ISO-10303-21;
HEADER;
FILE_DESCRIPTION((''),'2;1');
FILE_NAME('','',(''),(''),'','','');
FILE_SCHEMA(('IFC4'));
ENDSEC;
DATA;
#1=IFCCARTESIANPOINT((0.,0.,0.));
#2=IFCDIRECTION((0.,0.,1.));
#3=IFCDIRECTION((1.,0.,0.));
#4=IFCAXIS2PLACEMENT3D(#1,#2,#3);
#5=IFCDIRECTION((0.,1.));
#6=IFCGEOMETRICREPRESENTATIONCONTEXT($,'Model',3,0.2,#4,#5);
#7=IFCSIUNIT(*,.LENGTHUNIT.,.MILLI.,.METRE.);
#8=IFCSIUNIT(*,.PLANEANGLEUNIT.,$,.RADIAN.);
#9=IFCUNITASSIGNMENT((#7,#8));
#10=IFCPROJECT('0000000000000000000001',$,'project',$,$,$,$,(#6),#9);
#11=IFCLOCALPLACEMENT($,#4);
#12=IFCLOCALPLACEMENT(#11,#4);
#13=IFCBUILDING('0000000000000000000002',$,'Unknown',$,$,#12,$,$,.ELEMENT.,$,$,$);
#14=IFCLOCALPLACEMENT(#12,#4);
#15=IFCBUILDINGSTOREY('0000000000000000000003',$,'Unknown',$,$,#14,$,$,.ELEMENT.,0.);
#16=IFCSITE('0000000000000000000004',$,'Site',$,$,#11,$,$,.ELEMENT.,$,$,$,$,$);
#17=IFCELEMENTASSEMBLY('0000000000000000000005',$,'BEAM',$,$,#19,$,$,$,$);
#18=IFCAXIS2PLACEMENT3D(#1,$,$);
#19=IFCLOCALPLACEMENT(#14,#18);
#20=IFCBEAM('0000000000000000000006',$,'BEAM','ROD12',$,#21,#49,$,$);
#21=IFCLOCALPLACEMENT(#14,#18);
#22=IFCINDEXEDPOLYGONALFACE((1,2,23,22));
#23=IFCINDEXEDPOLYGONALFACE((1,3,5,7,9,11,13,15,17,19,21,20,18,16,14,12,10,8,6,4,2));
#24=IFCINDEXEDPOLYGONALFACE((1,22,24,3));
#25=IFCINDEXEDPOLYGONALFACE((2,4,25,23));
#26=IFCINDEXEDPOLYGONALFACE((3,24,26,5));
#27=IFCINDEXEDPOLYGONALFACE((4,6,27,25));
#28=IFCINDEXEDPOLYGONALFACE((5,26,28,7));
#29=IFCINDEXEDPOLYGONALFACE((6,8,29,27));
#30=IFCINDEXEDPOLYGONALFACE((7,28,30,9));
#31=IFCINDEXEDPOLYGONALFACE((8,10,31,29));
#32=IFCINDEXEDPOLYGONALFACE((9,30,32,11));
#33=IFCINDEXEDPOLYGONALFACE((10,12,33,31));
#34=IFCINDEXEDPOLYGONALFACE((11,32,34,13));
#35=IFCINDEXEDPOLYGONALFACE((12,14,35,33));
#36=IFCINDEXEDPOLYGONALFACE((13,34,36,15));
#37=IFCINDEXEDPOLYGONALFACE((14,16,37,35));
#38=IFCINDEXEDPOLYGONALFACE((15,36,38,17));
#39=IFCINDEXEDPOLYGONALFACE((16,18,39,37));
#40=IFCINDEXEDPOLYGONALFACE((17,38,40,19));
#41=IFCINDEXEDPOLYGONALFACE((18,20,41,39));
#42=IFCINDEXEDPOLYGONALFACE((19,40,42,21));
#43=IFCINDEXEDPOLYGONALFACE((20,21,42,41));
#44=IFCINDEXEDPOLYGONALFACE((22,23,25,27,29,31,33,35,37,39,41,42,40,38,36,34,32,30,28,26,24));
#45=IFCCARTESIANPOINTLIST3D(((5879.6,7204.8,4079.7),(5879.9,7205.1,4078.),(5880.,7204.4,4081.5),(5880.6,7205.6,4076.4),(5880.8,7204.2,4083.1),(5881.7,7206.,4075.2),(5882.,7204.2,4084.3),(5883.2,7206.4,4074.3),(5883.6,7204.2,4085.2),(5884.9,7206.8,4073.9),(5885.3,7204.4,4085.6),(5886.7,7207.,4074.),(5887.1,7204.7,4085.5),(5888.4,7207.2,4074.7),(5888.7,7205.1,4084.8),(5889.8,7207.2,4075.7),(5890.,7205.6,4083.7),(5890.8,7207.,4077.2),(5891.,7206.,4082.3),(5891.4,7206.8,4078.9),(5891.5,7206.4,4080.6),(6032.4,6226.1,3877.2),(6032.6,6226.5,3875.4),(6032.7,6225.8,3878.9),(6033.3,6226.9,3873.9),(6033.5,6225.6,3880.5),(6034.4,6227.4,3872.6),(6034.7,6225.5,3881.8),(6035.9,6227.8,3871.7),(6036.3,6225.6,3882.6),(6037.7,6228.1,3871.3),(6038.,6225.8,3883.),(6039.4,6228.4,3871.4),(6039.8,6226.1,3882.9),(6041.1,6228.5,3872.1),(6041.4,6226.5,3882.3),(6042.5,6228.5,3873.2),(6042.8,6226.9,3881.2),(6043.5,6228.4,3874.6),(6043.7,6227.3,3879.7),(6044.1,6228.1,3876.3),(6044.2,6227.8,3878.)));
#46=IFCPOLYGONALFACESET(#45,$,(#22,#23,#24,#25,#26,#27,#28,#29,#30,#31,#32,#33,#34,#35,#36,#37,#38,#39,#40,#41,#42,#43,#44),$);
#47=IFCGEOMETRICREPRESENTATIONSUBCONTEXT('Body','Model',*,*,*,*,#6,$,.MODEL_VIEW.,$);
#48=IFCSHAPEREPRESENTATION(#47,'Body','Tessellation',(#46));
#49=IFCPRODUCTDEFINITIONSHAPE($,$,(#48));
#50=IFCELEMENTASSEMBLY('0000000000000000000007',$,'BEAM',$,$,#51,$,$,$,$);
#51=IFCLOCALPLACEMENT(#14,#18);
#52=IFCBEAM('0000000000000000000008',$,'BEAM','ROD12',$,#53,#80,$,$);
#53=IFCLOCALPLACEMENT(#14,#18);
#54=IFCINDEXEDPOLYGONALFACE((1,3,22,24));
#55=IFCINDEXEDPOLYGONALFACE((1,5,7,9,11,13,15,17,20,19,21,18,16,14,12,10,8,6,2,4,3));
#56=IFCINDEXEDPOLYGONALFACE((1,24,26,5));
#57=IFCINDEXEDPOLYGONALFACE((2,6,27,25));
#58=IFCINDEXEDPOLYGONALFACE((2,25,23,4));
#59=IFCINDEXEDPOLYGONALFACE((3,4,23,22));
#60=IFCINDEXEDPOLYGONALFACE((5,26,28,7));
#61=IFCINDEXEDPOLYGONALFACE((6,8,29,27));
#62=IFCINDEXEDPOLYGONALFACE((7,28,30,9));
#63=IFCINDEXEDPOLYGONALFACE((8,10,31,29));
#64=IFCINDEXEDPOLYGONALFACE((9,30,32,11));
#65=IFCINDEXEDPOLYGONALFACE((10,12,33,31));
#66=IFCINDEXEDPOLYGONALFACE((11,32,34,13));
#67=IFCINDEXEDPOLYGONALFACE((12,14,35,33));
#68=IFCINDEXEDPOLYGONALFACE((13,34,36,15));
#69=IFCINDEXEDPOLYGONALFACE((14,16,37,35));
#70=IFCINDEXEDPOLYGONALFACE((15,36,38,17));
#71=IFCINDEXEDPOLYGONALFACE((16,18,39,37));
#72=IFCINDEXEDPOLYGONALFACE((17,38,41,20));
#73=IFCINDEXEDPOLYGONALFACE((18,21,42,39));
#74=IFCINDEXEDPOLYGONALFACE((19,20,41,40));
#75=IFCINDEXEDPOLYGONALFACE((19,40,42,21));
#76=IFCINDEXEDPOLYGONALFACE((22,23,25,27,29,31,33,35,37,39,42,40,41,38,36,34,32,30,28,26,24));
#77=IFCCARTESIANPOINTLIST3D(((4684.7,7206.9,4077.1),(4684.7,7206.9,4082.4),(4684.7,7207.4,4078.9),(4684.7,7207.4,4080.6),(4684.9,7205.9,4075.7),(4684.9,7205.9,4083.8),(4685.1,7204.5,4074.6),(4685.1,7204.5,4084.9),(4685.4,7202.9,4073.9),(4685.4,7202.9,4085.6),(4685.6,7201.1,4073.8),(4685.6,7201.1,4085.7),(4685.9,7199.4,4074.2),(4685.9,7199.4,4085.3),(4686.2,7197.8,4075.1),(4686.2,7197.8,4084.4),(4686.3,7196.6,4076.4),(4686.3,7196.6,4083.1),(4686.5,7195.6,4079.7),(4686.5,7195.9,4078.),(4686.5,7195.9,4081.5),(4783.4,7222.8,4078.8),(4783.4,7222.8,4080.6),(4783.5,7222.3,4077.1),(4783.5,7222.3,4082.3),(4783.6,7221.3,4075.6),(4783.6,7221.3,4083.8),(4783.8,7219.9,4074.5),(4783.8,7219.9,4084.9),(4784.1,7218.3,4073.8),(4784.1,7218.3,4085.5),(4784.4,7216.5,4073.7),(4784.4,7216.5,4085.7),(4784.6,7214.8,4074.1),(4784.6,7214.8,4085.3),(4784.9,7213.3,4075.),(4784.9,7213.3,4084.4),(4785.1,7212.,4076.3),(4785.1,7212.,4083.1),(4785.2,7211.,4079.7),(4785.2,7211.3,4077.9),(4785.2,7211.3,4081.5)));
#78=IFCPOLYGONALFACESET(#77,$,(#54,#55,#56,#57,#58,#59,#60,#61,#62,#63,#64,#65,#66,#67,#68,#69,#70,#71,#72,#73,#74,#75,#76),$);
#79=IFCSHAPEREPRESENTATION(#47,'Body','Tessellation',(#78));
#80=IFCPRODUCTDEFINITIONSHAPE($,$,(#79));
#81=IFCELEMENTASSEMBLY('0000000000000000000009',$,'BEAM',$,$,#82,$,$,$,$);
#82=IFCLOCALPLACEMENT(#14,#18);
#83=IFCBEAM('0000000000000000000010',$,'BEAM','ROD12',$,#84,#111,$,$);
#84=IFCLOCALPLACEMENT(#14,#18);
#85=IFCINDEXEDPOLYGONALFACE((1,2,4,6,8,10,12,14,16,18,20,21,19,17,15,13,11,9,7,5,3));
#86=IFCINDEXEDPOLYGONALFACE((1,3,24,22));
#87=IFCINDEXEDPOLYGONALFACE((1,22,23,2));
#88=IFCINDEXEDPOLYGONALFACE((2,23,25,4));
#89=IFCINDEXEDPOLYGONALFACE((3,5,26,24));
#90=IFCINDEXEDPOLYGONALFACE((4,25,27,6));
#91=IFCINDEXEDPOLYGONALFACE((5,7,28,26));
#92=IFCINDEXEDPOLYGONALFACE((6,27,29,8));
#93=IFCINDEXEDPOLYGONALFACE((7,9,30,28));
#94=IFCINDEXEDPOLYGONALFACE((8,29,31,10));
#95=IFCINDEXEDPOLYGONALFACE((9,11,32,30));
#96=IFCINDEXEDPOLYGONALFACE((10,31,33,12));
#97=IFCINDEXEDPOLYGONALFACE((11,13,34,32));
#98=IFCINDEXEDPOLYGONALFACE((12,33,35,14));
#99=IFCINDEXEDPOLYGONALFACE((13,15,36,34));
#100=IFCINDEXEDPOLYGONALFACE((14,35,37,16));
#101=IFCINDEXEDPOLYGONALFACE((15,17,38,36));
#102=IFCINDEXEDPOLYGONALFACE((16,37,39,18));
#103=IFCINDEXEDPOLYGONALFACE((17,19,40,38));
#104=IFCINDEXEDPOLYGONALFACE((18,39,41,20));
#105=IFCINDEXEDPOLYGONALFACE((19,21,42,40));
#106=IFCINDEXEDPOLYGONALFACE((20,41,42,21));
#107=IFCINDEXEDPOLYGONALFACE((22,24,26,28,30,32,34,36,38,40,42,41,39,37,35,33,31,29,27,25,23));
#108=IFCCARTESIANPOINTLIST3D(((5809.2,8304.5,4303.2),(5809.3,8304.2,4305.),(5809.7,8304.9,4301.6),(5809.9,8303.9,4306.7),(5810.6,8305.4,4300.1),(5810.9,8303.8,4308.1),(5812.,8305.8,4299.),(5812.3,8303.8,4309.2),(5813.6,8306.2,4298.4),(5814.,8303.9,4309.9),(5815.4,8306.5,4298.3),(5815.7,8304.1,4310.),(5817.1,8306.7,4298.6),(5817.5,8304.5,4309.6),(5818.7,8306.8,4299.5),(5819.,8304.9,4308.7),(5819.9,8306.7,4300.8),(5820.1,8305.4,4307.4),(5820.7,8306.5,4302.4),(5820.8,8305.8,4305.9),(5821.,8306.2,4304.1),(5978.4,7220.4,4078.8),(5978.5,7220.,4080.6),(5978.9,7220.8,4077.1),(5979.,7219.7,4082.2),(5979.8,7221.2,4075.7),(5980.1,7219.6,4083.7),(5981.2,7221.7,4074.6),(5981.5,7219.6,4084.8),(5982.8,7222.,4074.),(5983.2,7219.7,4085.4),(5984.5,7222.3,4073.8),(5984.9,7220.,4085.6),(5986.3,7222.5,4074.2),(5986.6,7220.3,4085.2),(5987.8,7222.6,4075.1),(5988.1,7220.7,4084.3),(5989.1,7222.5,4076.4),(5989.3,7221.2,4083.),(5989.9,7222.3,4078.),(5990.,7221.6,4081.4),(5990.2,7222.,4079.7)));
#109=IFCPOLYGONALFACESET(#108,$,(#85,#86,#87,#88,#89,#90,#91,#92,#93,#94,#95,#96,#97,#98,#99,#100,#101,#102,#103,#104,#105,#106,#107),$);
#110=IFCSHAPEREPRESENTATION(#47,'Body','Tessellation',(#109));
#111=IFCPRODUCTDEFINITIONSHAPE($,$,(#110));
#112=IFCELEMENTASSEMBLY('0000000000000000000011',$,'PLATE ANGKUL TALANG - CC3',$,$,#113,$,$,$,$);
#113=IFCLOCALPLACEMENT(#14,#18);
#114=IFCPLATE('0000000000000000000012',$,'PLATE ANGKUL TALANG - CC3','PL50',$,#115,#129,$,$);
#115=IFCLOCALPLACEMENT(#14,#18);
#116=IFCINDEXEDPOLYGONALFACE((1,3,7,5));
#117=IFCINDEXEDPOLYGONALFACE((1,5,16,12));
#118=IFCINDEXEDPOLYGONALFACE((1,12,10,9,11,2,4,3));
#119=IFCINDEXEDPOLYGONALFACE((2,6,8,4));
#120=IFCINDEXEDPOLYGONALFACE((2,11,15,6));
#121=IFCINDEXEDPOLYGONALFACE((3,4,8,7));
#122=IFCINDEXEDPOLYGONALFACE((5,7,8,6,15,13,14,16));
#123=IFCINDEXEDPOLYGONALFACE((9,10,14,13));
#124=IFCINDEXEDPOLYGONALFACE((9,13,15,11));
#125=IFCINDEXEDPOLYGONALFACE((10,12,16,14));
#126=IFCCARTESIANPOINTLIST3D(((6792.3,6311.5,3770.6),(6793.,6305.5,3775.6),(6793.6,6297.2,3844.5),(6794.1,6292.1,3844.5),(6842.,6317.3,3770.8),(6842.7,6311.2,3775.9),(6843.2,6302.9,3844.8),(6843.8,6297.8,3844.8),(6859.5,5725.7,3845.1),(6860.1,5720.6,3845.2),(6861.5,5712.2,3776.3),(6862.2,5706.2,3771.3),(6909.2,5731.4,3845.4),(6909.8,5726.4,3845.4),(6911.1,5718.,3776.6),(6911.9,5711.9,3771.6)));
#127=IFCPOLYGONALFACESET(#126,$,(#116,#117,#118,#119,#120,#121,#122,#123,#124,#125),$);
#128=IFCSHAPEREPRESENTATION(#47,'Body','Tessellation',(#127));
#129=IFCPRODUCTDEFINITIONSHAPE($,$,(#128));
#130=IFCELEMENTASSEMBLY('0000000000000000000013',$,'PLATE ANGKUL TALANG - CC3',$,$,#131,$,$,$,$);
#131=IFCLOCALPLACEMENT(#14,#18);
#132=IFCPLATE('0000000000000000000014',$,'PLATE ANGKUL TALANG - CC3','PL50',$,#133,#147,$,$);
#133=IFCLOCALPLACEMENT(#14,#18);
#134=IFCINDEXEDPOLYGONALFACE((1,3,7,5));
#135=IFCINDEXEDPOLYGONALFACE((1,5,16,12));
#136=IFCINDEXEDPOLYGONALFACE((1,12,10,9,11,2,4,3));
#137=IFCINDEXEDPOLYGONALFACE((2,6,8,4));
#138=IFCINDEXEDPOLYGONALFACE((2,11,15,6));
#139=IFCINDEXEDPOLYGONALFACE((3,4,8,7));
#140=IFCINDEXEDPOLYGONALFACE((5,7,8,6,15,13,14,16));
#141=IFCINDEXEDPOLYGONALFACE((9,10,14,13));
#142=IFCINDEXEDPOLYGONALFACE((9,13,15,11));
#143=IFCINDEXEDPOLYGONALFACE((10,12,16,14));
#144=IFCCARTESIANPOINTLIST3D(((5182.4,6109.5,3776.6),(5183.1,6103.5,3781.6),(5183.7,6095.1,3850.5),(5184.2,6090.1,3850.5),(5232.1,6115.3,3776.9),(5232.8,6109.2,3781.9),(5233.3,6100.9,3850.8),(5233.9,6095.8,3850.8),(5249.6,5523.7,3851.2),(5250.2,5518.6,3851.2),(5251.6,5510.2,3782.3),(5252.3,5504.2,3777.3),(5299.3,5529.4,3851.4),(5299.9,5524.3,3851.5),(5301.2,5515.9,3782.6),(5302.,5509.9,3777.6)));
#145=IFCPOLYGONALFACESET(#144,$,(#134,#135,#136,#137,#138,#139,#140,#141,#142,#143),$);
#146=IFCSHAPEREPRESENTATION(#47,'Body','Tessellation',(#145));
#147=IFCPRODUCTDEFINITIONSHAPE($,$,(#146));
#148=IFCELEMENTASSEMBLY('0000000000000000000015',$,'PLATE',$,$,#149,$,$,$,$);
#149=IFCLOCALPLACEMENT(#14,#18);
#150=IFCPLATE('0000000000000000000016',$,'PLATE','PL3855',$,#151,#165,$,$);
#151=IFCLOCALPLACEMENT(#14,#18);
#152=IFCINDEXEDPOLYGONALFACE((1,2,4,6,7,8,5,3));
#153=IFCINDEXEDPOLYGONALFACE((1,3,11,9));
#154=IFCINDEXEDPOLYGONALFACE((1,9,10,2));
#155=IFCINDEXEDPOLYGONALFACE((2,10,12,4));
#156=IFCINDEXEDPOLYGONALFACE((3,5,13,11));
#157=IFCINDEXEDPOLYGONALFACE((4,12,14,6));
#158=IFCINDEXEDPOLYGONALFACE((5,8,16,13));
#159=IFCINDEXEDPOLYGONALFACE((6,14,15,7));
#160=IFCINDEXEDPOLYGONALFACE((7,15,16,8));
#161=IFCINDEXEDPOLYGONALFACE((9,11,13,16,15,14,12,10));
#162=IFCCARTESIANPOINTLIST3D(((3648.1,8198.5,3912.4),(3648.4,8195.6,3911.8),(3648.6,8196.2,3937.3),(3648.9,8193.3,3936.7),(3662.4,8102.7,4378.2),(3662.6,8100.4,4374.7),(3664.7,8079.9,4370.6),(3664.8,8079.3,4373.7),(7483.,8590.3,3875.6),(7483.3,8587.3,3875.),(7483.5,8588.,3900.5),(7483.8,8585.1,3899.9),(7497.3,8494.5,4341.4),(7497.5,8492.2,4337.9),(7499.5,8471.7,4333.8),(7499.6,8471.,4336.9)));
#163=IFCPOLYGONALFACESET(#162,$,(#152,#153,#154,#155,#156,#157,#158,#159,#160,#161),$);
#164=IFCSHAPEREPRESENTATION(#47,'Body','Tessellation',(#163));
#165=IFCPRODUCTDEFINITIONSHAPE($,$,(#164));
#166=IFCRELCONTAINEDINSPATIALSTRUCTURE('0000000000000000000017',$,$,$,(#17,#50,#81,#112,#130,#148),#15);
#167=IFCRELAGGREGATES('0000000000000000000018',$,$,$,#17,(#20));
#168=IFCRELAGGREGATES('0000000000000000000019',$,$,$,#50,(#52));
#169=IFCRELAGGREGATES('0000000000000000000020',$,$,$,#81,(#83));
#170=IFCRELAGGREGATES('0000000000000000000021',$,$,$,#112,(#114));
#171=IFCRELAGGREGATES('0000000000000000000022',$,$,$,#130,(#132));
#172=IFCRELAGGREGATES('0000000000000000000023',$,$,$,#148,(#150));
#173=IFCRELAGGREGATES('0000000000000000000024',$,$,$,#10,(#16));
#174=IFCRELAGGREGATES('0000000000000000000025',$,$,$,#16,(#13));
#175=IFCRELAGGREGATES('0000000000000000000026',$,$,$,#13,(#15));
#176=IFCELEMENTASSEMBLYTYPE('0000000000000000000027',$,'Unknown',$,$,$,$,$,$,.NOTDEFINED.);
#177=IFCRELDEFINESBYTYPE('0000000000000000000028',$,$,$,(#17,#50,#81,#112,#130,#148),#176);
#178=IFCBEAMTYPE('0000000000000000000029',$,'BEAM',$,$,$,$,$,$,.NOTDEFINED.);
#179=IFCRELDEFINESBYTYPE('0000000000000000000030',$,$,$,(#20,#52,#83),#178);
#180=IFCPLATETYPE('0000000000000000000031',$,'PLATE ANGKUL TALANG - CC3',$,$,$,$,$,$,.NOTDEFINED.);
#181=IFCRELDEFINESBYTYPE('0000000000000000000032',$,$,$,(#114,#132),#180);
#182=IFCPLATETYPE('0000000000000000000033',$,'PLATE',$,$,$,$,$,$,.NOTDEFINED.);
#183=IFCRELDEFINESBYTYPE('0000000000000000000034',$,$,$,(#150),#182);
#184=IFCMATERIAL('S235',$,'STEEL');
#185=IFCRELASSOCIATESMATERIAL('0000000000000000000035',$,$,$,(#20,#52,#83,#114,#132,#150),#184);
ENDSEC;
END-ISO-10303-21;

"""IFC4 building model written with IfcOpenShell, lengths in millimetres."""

from ifc_helpers import new_model, si_unit, direction, frame, origin_with_axes, origin_2d_with_axis, place, context, subcontext, project, spatial, line, indexed_curve, circle, outline, extrude, material, material_profile, profile_set, profile_usage, type_object, element, aggregate, save


model = new_model("IFC4")

# Units and contexts
model_context = context("Model", 3, precision=0.2, world=origin_with_axes(), true_north=direction((0.0, 1.0)))
body_context = subcontext(model_context, "Body", "Model", "MODEL_VIEW")
ifc_project = project(units=[si_unit("LENGTHUNIT", "METRE", prefix="MILLI"), si_unit("PLANEANGLEUNIT", "RADIAN")], contexts=[model_context])

# Site, building, storey
site_placement = place(None, origin_with_axes())
site = spatial("IfcSite", under=ifc_project, at=site_placement, Name="Site", CompositionType="ELEMENT")
building_placement = place(site_placement, origin_with_axes())
building = spatial("IfcBuilding", under=site, at=building_placement, Name="Unknown", CompositionType="ELEMENT")
storey_placement = place(building_placement, origin_with_axes())
storey = spatial("IfcBuildingStorey", under=building, at=storey_placement, Name="Unknown", CompositionType="ELEMENT", Elevation=0.0)

# Element assemblies, beams
element_assembly_type = type_object("IfcElementAssemblyType", Name="Unknown", PredefinedType="NOTDEFINED")
ifc_material_1 = material(Name="S235", Category="STEEL")
ifc_material_profile_1 = material_profile(ifc_material_1, circle(Radius=6.0, at=origin_2d_with_axis()), Name="ROD12")
ifc_profile_set_1 = profile_set([ifc_material_profile_1])
ifc_profile_usage_1 = profile_usage(ifc_profile_set_1, cardinal=5)
beam_type_1 = type_object("IfcBeamType", Name="BEAM", PredefinedType="NOTDEFINED")
assembly_1_placement = place(storey_placement, frame((5885.6, 7205.7, 4079.7), z_axis=(-0.988043, -0.154176, 0.0), x_axis=(0.151049, -0.968005, -0.200378)))
assembly_1 = element("IfcElementAssembly", 1, at=assembly_1_placement, inside=storey, type_object=element_assembly_type, Name="BEAM")
beam_1_placement = place(assembly_1_placement, origin_with_axes())
beam_1 = element("IfcBeam", 2, at=beam_1_placement, type_object=beam_type_1, material=ifc_profile_usage_1, Name="BEAM", Description="ROD12", context=body_context, shape_type="SolidModel", body=[
    extrude(circle(Radius=6.0, at=origin_2d_with_axis()), frame((0.0, 0.0, 0.0), z_axis=(-1.0, 0.0, 0.0), x_axis=(0.0, 0.0, 1.0)), (0.0, 0.0, -1.0), 1011.0),
])
aggregate(assembly_1, [beam_1])
assembly_2_placement = place(storey_placement, frame((4685.6, 7201.5, 4079.7), z_axis=(0.154276, -0.988028, 0.0), x_axis=(0.988028, 0.154276, -0.000497)))
assembly_2 = element("IfcElementAssembly", 3, at=assembly_2_placement, inside=storey, type_object=element_assembly_type, Name="BEAM")
beam_2_placement = place(assembly_2_placement, origin_with_axes())
beam_2 = element("IfcBeam", 4, at=beam_2_placement, type_object=beam_type_1, material=ifc_profile_usage_1, Name="BEAM", Description="ROD12", context=body_context, shape_type="SolidModel", body=[
    extrude(circle(Radius=6.0, at=origin_2d_with_axis()), frame((0.0, 0.0, 0.0), z_axis=(-1.0, 0.0, 0.0), x_axis=(0.0, 0.0, 1.0)), (0.0, 0.0, -1.0), 99.9),
])
aggregate(assembly_2, [beam_2])
assembly_3_placement = place(storey_placement, frame((5984.3, 7221.1, 4079.7), z_axis=(0.988043, 0.154176, 0.0), x_axis=(-0.151049, 0.968005, 0.200378)))
assembly_3 = element("IfcElementAssembly", 5, at=assembly_3_placement, inside=storey, type_object=element_assembly_type, Name="BEAM")
beam_3_placement = place(assembly_3_placement, origin_with_axes())
beam_3 = element("IfcBeam", 6, at=beam_3_placement, type_object=beam_type_1, material=ifc_profile_usage_1, Name="BEAM", Description="ROD12", context=body_context, shape_type="SolidModel", body=[
    extrude(circle(Radius=6.0, at=origin_2d_with_axis()), frame((0.0, 0.0, 0.0), z_axis=(-1.0, 0.0, 0.0), x_axis=(0.0, 0.0, 1.0)), (0.0, 0.0, -1.0), 1120.0),
])
aggregate(assembly_3, [beam_3])

# Element assemblies, plates
assembly_4_placement = place(storey_placement, frame((6818.4, 6300.0, 3844.6), z_axis=(-0.99339, -0.114647, -0.005686), x_axis=(-0.01641, 0.190863, -0.98148)))
assembly_4 = element("IfcElementAssembly", 7, at=assembly_4_placement, inside=storey, type_object=element_assembly_type, Name="PLATE ANGKUL TALANG - CC3")
ifc_material_profile_2 = material_profile(ifc_material_1, outline(indexed_curve([(0.0, 0.0), (75.4, 0.0), (-42.1, 598.0), (-111.8, 569.5), (-110.8, 564.5), (-45.8, 591.0), (69.3, 5.0), (-1.0, 5.0)], segments=[line(1, 2, 3, 4, 5, 6, 7, 8, 1)])), Name="PL50")
ifc_profile_set_2 = profile_set([ifc_material_profile_2])
ifc_profile_usage_2 = profile_usage(ifc_profile_set_2, cardinal=5)
plate_type_1 = type_object("IfcPlateType", Name="PLATE ANGKUL TALANG - CC3", PredefinedType="NOTDEFINED")
plate_1_placement = place(assembly_4_placement, origin_with_axes())
plate_1 = element("IfcPlate", 8, at=plate_1_placement, type_object=plate_type_1, material=ifc_profile_usage_2, Name="PLATE ANGKUL TALANG - CC3", Description="PL50", context=body_context, shape_type="SolidModel", body=[
    extrude(outline(indexed_curve([(0.0, 0.0), (75.4, 0.0), (-42.1, 598.0), (-111.8, 569.5), (-110.8, 564.5), (-45.8, 591.0), (69.3, 5.0), (-1.0, 5.0)], segments=[line(1, 2, 3, 4, 5, 6, 7, 8, 1)])), frame((0.0, 0.0, 25.0), z_axis=(0.0, 0.0, 1.0), x_axis=(1.0, 0.0, 0.0)), (0.0, 0.0, -1.0), 50.0),
])
aggregate(assembly_4, [plate_1])
assembly_5_placement = place(storey_placement, frame((5208.5, 6098.0, 3850.7), z_axis=(-0.99339, -0.114647, -0.005686), x_axis=(-0.01641, 0.190863, -0.98148)))
assembly_5 = element("IfcElementAssembly", 9, at=assembly_5_placement, inside=storey, type_object=element_assembly_type, Name="PLATE ANGKUL TALANG - CC3")
plate_2_placement = place(assembly_5_placement, origin_with_axes())
plate_2 = element("IfcPlate", 10, at=plate_2_placement, type_object=plate_type_1, material=ifc_profile_usage_2, Name="PLATE ANGKUL TALANG - CC3", Description="PL50", context=body_context, shape_type="SolidModel", body=[
    extrude(outline(indexed_curve([(0.0, 0.0), (75.4, 0.0), (-42.1, 598.0), (-111.8, 569.5), (-110.8, 564.5), (-45.8, 591.0), (69.3, 5.0), (-1.0, 5.0)], segments=[line(1, 2, 3, 4, 5, 6, 7, 8, 1)])), frame((0.0, 0.0, 25.0), z_axis=(0.0, 0.0, 1.0), x_axis=(1.0, 0.0, 0.0)), (0.0, 0.0, -1.0), 50.0),
])
aggregate(assembly_5, [plate_2])
assembly_6_placement = place(storey_placement, frame((5582.2, 8275.2, 4355.3), z_axis=(-0.994777, -0.101628, 0.009549), x_axis=(-0.097939, 0.976642, 0.191257)))
assembly_6 = element("IfcElementAssembly", 11, at=assembly_6_placement, inside=storey, type_object=element_assembly_type, Name="PLATE")
ifc_material_profile_3 = material_profile(ifc_material_1, outline(indexed_curve([(0.0, 0.0), (24.0, 0.0), (32.4, 450.9), (29.8, 475.8), (26.9, 475.8), (29.4, 450.9), (21.0, 3.0), (0.0, 3.1)], segments=[line(1, 2, 3, 4, 5, 6, 7, 8, 1)])), Name="PL3855")
ifc_profile_set_3 = profile_set([ifc_material_profile_3])
ifc_profile_usage_3 = profile_usage(ifc_profile_set_3, cardinal=5)
plate_type_2 = type_object("IfcPlateType", Name="PLATE", PredefinedType="NOTDEFINED")
plate_3_placement = place(assembly_6_placement, origin_with_axes())
plate_3 = element("IfcPlate", 12, at=plate_3_placement, type_object=plate_type_2, material=ifc_profile_usage_3, Name="PLATE", Description="PL3855", context=body_context, shape_type="SolidModel", body=[
    extrude(outline(indexed_curve([(0.0, 0.0), (24.0, 0.0), (32.4, 450.9), (29.8, 475.8), (26.9, 475.8), (29.4, 450.9), (21.0, 3.0), (0.0, 3.1)], segments=[line(1, 2, 3, 4, 5, 6, 7, 8, 1)])), frame((0.0, 0.0, 1927.5), z_axis=(0.0, 0.0, 1.0), x_axis=(1.0, 0.0, 0.0)), (0.0, 0.0, -1.0), 3855.0),
])
aggregate(assembly_6, [plate_3])

save(model, "model.ifc")
